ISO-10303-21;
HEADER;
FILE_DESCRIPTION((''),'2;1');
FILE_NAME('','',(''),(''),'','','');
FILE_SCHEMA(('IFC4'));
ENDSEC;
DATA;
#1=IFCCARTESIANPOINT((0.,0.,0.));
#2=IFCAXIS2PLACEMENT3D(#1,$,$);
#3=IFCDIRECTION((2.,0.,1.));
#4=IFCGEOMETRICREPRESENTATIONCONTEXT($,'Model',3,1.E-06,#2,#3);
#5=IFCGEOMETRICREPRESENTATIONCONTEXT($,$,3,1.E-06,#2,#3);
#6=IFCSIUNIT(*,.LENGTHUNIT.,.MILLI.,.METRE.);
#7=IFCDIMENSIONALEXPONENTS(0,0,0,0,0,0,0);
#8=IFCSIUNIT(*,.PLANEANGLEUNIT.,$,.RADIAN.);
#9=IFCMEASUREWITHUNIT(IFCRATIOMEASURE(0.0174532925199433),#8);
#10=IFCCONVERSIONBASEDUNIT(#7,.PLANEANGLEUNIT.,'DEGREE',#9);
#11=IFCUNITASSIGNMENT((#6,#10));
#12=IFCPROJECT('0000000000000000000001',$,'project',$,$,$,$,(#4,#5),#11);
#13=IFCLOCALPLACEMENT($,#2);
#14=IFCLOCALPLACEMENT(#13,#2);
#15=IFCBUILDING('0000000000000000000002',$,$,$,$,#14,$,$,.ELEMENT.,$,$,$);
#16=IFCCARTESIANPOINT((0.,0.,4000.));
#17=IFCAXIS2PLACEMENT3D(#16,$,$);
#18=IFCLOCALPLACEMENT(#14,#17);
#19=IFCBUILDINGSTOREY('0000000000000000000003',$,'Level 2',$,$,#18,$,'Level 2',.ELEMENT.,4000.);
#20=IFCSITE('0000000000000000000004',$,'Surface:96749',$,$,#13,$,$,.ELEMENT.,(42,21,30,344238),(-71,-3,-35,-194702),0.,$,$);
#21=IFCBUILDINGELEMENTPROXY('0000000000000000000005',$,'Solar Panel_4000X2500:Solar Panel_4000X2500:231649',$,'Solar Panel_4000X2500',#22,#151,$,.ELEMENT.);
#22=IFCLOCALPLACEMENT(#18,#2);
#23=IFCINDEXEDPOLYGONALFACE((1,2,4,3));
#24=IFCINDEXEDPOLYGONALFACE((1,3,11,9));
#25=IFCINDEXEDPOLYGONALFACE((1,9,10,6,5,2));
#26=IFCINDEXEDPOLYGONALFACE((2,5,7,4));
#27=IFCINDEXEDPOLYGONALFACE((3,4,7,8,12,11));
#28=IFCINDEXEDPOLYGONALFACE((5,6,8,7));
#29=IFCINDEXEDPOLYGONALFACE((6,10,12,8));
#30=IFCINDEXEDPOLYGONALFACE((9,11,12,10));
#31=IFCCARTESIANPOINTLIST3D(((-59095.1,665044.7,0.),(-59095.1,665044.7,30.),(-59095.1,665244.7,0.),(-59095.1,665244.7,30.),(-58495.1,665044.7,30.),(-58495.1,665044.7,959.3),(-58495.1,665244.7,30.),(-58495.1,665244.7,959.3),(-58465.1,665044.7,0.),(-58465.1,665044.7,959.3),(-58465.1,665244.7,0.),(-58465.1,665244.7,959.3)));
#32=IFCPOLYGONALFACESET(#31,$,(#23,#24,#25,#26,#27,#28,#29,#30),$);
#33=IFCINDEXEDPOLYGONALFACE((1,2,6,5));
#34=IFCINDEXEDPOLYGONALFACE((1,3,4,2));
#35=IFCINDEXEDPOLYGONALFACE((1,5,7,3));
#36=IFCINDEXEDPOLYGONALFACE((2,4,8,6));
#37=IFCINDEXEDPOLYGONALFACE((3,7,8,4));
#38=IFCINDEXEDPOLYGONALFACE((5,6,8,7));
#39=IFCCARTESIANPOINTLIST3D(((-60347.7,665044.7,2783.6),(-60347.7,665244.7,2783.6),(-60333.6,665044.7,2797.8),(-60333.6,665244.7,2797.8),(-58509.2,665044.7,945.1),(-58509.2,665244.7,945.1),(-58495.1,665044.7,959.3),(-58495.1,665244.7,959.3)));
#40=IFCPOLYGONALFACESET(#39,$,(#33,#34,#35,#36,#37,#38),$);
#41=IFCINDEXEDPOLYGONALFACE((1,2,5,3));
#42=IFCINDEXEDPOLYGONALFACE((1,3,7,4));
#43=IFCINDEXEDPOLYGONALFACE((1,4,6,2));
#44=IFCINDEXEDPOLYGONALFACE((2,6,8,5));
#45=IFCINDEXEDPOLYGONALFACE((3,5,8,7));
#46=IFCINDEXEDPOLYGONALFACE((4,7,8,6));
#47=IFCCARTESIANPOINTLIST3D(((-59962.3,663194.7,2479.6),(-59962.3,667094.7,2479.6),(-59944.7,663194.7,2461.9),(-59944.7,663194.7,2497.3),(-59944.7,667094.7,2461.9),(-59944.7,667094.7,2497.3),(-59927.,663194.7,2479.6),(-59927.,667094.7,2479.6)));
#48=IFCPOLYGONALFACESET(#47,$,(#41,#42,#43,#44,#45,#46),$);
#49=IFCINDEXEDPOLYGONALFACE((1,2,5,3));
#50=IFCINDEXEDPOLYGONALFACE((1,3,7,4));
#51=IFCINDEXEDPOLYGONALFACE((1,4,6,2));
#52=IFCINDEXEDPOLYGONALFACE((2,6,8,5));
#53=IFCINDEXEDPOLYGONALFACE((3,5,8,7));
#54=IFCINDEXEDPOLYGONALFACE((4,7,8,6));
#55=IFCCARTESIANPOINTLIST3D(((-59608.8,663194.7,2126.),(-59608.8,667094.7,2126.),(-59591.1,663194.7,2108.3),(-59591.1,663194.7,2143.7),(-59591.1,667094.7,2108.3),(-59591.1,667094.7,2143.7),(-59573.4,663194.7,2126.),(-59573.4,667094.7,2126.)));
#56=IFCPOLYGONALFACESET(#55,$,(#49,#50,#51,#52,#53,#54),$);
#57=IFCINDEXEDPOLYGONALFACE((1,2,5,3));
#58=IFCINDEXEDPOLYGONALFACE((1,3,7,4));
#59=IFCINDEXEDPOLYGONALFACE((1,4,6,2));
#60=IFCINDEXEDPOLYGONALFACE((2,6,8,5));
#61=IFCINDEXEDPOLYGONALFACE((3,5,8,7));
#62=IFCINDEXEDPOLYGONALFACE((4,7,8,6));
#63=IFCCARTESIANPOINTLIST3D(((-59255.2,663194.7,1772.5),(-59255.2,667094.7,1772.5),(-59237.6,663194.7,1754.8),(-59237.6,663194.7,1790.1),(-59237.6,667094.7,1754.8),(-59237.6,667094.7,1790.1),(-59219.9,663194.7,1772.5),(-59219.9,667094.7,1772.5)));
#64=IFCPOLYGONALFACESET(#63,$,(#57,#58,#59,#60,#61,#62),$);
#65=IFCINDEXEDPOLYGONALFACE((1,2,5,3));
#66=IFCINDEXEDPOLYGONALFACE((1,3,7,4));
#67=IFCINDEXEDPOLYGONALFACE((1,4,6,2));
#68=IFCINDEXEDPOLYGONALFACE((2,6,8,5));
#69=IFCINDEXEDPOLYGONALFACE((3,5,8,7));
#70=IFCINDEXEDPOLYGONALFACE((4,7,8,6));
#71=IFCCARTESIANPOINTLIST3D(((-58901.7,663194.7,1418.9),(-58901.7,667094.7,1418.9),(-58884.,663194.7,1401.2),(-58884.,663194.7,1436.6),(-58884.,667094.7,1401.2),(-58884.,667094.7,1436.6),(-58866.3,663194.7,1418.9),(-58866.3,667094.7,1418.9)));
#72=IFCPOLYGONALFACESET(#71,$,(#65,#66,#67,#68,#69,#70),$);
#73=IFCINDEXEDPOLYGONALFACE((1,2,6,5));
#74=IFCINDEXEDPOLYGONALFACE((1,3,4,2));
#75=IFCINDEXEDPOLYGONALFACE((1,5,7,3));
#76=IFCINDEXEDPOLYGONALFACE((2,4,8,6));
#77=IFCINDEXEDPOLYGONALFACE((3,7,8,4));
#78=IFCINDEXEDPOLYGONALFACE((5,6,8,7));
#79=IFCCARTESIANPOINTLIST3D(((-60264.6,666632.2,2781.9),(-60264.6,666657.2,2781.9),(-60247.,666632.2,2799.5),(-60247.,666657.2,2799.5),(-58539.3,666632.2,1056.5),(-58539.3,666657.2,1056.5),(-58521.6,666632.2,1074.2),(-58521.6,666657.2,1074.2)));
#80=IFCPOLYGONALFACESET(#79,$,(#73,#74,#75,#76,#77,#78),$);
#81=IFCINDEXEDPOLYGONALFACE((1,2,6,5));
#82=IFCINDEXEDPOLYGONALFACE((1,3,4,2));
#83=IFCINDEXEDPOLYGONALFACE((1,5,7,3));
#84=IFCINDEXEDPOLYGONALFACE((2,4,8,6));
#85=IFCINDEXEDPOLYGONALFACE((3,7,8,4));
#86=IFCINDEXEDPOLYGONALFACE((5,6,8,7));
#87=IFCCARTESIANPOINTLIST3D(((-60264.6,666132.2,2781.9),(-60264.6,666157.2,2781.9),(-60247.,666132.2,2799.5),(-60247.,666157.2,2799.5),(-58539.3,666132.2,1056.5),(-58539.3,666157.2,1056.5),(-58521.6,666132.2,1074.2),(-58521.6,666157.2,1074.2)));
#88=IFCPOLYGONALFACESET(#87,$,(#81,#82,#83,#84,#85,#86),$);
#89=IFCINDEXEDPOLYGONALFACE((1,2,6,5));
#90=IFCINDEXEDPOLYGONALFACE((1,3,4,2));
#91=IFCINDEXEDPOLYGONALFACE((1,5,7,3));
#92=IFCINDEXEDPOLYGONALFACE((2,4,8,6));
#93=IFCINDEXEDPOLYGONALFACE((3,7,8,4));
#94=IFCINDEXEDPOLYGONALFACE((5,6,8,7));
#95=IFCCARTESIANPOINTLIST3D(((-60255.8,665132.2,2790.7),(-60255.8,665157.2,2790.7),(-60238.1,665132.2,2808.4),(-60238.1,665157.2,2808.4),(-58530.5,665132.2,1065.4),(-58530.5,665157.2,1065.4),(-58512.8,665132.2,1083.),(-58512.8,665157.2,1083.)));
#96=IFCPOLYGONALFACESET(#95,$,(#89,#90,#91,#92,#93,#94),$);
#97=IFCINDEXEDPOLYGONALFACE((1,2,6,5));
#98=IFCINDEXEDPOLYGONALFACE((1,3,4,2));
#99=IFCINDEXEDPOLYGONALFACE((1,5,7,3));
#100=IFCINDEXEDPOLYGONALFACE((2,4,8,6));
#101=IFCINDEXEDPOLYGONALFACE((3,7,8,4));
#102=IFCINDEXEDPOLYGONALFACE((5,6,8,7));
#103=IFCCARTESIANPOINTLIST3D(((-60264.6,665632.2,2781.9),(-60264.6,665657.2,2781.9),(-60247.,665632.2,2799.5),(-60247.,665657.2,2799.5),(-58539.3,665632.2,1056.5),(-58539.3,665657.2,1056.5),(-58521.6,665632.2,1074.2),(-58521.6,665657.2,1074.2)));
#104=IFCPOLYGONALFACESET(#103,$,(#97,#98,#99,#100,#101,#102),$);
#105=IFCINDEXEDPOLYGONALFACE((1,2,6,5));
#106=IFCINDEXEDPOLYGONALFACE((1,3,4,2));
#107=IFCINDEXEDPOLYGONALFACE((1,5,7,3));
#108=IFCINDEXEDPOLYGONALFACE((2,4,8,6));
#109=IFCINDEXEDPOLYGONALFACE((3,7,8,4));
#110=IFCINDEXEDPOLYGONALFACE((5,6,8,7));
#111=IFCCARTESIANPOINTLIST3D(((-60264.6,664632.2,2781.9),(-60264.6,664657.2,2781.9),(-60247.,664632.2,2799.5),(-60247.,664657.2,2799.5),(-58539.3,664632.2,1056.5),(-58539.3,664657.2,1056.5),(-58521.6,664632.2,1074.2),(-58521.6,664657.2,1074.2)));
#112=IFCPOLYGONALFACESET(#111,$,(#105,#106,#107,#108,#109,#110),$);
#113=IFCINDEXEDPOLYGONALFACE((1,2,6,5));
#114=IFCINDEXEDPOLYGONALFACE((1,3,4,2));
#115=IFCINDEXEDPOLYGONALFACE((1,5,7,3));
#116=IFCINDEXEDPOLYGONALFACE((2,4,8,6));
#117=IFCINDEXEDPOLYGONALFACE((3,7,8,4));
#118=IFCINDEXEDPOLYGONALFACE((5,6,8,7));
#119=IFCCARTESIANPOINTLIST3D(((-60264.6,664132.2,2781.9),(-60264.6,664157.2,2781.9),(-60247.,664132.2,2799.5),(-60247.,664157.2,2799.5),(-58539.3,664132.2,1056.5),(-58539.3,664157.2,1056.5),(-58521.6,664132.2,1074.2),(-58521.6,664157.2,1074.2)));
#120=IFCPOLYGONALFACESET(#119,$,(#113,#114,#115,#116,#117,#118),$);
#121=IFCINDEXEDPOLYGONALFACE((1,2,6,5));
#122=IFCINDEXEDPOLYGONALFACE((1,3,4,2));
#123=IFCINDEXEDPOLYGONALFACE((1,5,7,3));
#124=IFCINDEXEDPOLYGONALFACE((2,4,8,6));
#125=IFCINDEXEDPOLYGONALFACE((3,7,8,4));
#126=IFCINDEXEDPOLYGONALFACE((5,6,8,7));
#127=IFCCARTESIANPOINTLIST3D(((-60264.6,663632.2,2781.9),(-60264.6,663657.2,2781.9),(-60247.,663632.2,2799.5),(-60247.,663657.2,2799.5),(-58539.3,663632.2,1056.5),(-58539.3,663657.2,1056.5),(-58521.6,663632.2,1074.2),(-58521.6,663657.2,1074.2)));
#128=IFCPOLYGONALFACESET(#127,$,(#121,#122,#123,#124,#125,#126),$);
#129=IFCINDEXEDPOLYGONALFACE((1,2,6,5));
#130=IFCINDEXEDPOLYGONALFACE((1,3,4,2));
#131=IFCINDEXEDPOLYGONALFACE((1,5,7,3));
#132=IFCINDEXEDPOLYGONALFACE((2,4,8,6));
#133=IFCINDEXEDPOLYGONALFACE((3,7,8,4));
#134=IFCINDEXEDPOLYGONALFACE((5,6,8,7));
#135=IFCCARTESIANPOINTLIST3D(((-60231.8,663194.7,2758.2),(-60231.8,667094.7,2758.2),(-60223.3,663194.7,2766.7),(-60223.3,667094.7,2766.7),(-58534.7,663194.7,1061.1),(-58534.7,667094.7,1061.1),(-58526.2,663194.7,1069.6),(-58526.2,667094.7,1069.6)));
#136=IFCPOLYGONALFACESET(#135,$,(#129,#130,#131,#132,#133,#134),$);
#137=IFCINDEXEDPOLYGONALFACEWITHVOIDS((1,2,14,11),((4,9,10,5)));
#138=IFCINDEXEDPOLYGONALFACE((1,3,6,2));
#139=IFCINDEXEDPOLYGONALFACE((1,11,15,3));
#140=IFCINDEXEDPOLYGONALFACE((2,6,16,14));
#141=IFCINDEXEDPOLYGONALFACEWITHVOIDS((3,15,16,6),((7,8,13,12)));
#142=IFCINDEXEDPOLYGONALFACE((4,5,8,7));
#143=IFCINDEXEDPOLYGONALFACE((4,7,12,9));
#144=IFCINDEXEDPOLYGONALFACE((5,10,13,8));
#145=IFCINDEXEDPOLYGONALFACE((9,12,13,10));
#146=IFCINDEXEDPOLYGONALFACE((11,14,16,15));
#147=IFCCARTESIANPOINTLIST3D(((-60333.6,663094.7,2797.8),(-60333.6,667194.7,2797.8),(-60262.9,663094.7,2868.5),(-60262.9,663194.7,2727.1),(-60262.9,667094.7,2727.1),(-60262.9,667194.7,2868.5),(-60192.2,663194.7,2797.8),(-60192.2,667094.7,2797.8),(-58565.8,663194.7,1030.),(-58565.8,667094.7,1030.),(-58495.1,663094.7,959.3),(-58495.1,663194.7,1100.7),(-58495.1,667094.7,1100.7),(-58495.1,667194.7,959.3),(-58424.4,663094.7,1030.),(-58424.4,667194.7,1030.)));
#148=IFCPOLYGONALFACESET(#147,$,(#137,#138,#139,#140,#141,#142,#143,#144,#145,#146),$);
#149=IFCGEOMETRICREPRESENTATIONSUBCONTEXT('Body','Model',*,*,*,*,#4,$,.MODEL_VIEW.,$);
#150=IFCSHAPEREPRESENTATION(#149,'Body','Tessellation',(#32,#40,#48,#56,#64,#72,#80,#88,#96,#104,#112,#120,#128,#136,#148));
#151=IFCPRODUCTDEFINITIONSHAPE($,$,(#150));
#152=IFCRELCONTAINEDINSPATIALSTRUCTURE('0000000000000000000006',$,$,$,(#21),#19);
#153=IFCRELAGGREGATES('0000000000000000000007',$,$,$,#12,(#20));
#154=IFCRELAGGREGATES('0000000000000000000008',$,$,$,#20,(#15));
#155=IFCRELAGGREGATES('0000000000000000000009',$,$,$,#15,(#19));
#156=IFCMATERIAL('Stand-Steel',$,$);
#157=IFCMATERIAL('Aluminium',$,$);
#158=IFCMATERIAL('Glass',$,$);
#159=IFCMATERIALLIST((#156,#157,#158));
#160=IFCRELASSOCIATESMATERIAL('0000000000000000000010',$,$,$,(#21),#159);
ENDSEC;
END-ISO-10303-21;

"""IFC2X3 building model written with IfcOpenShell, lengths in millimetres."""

from ifc_helpers import new_model, entity, si_unit, converted_unit, direction, frame, frame_2d, origin, origin_2d_with_axis, place, context, subcontext, project, spatial, polyline, rectangle, outline, extrude, source, transform, mapped, material, material_list, element, save


model = new_model("IFC2X3")

# Units and contexts
model_context = context("Model", 3, precision=1e-06, world=origin(), true_north=direction((2.0, 0.0, 1.0)))
context_of_model = context(None, 3, precision=1e-06, world=origin(), true_north=direction((2.0, 0.0, 1.0)))
body_context = subcontext(model_context, "Body", "Model", "MODEL_VIEW")
ifc_project = project(units=[si_unit("LENGTHUNIT", "METRE", prefix="MILLI"), converted_unit("PLANEANGLEUNIT", "DEGREE", entity("IfcRatioMeasure", 0.0174532925199433), si_unit("PLANEANGLEUNIT", "RADIAN"), dimensions=[0, 0, 0, 0, 0, 0, 0])], contexts=[model_context, context_of_model])

# Site, building, storey
site_placement = place(None, origin())
site = spatial("IfcSite", under=ifc_project, at=site_placement, Name="Surface:96749", CompositionType="ELEMENT", RefLatitude=(42, 21, 30, 344238), RefLongitude=(-71, -3, -35, -194702), RefElevation=0.0)
building_placement = place(site_placement, origin())
building = spatial("IfcBuilding", under=site, at=building_placement, CompositionType="ELEMENT")
storey_placement = place(building_placement, frame((0.0, 0.0, 4000.0)))
storey = spatial("IfcBuildingStorey", under=building, at=storey_placement, Name="Level 2", LongName="Level 2", CompositionType="ELEMENT", Elevation=4000.0)

# Building element proxy
ifc_material_1 = material(Name="Stand-Steel")
ifc_material_2 = material(Name="Aluminium")
ifc_material_3 = material(Name="Glass")
shared_shape = source(origin(), body_context, "Body", "SweptSolid", [
    extrude(outline(polyline([(-629.5, -220.0), (329.8, -220.0), (329.8, 410.0), (299.8, 410.0), (299.8, -190.0), (-629.5, -190.0), (-629.5, -220.0)])), frame((-190.0, -100.0, 299.8), z_axis=(0.0, 1.0, 0.0), x_axis=(0.0, 0.0, -1.0)), (0.0, 0.0, 1.0), 200.0),
    extrude(rectangle(XDim=20.0, YDim=200.0, at=frame_2d((0.0, 0.0), x_axis=(0.0, 1.0))), frame((-7.1, 0.0, 922.2), z_axis=(-0.707107, 0.0, 0.707107), x_axis=(0.0, 1.0, 0.0)), (0.0, 0.0, 1.0), 2600.0),
    extrude(rectangle(XDim=25.0, YDim=25.0, at=frame_2d((0.0, 0.0), x_axis=(1.0, 0.0))), frame((-1449.6, -1950.0, 2449.6), z_axis=(0.0, 1.0, 0.0), x_axis=(-0.707107, 0.0, -0.707107)), (0.0, 0.0, 1.0), 3900.0),
    extrude(rectangle(XDim=25.0, YDim=25.0, at=origin_2d_with_axis()), frame((-1096.0, -1950.0, 2096.0), z_axis=(0.0, 1.0, 0.0), x_axis=(-0.707107, 0.0, -0.707107)), (0.0, 0.0, 1.0), 3900.0),
    extrude(rectangle(XDim=25.0, YDim=25.0, at=origin_2d_with_axis()), frame((-742.5, -1950.0, 1742.5), z_axis=(0.0, 1.0, 0.0), x_axis=(-0.707107, 0.0, -0.707107)), (0.0, 0.0, 1.0), 3900.0),
    extrude(rectangle(XDim=25.0, YDim=25.0, at=frame_2d((0.0, 0.0), x_axis=(1.0, 0.0))), frame((-388.9, -1950.0, 1388.9), z_axis=(0.0, 1.0, 0.0), x_axis=(-0.707107, 0.0, -0.707107)), (0.0, 0.0, 1.0), 3900.0),
    extrude(rectangle(XDim=25.0, YDim=25.0, at=frame_2d((0.0, 0.0), x_axis=(0.0, 1.0))), frame((-35.4, 1500.0, 1035.4), z_axis=(-0.707107, 0.0, 0.707107), x_axis=(0.0, 1.0, 0.0)), (0.0, 0.0, 1.0), 2440.0),
    extrude(rectangle(XDim=25.0, YDim=25.0, at=frame_2d((0.0, 0.0), x_axis=(0.0, 1.0))), frame((-35.4, 1000.0, 1035.4), z_axis=(-0.707107, 0.0, 0.707107), x_axis=(0.0, 1.0, 0.0)), (0.0, 0.0, 1.0), 2440.0),
    extrude(rectangle(XDim=25.0, YDim=25.0, at=frame_2d((0.0, 0.0), x_axis=(0.0, 1.0))), frame((-26.5, 0.0, 1044.2), z_axis=(-0.707107, 0.0, 0.707107), x_axis=(0.0, -1.0, 0.0)), (0.0, 0.0, 1.0), 2440.0),
    extrude(rectangle(XDim=25.0, YDim=25.0, at=frame_2d((0.0, 0.0), x_axis=(0.0, 1.0))), frame((-35.4, 500.0, 1035.4), z_axis=(-0.707107, 0.0, 0.707107), x_axis=(0.0, 1.0, 0.0)), (0.0, 0.0, 1.0), 2440.0),
    extrude(rectangle(XDim=25.0, YDim=25.0, at=frame_2d((0.0, 0.0), x_axis=(0.0, 1.0))), frame((-35.4, -500.0, 1035.4), z_axis=(-0.707107, 0.0, 0.707107), x_axis=(0.0, 1.0, 0.0)), (0.0, 0.0, 1.0), 2440.0),
    extrude(rectangle(XDim=25.0, YDim=25.0, at=frame_2d((0.0, 0.0), x_axis=(0.0, 1.0))), frame((-35.4, -1000.0, 1035.4), z_axis=(-0.707107, 0.0, 0.707107), x_axis=(0.0, 1.0, 0.0)), (0.0, 0.0, 1.0), 2440.0),
    extrude(rectangle(XDim=25.0, YDim=25.0, at=frame_2d((0.0, 0.0), x_axis=(0.0, 1.0))), frame((-35.4, -1500.0, 1035.4), z_axis=(-0.707107, 0.0, 0.707107), x_axis=(0.0, 1.0, 0.0)), (0.0, 0.0, 1.0), 2440.0),
    extrude(rectangle(XDim=2400.0, YDim=12.0, at=frame_2d((0.0, 0.0), x_axis=(1.0, 0.0))), frame((-883.9, -1950.0, 1883.9), z_axis=(0.0, 1.0, 0.0), x_axis=(0.707107, 0.0, -0.707107)), (0.0, 0.0, 1.0), 3900.0),
    extrude(outline(polyline([(-2050.0, -1300.0), (2050.0, -1300.0), (2050.0, 1300.0), (-2050.0, 1300.0), (-2050.0, -1300.0)]), holes=[polyline([(1950.0, -1200.0), (-1950.0, -1200.0), (-1950.0, 1200.0), (1950.0, 1200.0), (1950.0, -1200.0)])]), frame((-919.2, 0.0, 1848.5), z_axis=(0.707107, 0.0, 0.707107), x_axis=(0.0, 1.0, 0.0)), (0.0, 0.0, 1.0), 100.0),
])
ifc_material_list_1 = material_list([ifc_material_1, ifc_material_2, ifc_material_3])
proxy_1_placement = place(storey_placement, frame((-58495.1, 665144.7, 30.0)))
element("IfcBuildingElementProxy", 1, at=proxy_1_placement, inside=storey, material=ifc_material_list_1, Name="Solar Panel_4000X2500:Solar Panel_4000X2500:231649", ObjectType="Solar Panel_4000X2500", CompositionType="ELEMENT", context=body_context, shape_type="MappedRepresentation", body=[
    mapped(shared_shape, transform((0.0, 0.0, 0.0), scale=1.0)),
])

save(model, "model.ifc")
